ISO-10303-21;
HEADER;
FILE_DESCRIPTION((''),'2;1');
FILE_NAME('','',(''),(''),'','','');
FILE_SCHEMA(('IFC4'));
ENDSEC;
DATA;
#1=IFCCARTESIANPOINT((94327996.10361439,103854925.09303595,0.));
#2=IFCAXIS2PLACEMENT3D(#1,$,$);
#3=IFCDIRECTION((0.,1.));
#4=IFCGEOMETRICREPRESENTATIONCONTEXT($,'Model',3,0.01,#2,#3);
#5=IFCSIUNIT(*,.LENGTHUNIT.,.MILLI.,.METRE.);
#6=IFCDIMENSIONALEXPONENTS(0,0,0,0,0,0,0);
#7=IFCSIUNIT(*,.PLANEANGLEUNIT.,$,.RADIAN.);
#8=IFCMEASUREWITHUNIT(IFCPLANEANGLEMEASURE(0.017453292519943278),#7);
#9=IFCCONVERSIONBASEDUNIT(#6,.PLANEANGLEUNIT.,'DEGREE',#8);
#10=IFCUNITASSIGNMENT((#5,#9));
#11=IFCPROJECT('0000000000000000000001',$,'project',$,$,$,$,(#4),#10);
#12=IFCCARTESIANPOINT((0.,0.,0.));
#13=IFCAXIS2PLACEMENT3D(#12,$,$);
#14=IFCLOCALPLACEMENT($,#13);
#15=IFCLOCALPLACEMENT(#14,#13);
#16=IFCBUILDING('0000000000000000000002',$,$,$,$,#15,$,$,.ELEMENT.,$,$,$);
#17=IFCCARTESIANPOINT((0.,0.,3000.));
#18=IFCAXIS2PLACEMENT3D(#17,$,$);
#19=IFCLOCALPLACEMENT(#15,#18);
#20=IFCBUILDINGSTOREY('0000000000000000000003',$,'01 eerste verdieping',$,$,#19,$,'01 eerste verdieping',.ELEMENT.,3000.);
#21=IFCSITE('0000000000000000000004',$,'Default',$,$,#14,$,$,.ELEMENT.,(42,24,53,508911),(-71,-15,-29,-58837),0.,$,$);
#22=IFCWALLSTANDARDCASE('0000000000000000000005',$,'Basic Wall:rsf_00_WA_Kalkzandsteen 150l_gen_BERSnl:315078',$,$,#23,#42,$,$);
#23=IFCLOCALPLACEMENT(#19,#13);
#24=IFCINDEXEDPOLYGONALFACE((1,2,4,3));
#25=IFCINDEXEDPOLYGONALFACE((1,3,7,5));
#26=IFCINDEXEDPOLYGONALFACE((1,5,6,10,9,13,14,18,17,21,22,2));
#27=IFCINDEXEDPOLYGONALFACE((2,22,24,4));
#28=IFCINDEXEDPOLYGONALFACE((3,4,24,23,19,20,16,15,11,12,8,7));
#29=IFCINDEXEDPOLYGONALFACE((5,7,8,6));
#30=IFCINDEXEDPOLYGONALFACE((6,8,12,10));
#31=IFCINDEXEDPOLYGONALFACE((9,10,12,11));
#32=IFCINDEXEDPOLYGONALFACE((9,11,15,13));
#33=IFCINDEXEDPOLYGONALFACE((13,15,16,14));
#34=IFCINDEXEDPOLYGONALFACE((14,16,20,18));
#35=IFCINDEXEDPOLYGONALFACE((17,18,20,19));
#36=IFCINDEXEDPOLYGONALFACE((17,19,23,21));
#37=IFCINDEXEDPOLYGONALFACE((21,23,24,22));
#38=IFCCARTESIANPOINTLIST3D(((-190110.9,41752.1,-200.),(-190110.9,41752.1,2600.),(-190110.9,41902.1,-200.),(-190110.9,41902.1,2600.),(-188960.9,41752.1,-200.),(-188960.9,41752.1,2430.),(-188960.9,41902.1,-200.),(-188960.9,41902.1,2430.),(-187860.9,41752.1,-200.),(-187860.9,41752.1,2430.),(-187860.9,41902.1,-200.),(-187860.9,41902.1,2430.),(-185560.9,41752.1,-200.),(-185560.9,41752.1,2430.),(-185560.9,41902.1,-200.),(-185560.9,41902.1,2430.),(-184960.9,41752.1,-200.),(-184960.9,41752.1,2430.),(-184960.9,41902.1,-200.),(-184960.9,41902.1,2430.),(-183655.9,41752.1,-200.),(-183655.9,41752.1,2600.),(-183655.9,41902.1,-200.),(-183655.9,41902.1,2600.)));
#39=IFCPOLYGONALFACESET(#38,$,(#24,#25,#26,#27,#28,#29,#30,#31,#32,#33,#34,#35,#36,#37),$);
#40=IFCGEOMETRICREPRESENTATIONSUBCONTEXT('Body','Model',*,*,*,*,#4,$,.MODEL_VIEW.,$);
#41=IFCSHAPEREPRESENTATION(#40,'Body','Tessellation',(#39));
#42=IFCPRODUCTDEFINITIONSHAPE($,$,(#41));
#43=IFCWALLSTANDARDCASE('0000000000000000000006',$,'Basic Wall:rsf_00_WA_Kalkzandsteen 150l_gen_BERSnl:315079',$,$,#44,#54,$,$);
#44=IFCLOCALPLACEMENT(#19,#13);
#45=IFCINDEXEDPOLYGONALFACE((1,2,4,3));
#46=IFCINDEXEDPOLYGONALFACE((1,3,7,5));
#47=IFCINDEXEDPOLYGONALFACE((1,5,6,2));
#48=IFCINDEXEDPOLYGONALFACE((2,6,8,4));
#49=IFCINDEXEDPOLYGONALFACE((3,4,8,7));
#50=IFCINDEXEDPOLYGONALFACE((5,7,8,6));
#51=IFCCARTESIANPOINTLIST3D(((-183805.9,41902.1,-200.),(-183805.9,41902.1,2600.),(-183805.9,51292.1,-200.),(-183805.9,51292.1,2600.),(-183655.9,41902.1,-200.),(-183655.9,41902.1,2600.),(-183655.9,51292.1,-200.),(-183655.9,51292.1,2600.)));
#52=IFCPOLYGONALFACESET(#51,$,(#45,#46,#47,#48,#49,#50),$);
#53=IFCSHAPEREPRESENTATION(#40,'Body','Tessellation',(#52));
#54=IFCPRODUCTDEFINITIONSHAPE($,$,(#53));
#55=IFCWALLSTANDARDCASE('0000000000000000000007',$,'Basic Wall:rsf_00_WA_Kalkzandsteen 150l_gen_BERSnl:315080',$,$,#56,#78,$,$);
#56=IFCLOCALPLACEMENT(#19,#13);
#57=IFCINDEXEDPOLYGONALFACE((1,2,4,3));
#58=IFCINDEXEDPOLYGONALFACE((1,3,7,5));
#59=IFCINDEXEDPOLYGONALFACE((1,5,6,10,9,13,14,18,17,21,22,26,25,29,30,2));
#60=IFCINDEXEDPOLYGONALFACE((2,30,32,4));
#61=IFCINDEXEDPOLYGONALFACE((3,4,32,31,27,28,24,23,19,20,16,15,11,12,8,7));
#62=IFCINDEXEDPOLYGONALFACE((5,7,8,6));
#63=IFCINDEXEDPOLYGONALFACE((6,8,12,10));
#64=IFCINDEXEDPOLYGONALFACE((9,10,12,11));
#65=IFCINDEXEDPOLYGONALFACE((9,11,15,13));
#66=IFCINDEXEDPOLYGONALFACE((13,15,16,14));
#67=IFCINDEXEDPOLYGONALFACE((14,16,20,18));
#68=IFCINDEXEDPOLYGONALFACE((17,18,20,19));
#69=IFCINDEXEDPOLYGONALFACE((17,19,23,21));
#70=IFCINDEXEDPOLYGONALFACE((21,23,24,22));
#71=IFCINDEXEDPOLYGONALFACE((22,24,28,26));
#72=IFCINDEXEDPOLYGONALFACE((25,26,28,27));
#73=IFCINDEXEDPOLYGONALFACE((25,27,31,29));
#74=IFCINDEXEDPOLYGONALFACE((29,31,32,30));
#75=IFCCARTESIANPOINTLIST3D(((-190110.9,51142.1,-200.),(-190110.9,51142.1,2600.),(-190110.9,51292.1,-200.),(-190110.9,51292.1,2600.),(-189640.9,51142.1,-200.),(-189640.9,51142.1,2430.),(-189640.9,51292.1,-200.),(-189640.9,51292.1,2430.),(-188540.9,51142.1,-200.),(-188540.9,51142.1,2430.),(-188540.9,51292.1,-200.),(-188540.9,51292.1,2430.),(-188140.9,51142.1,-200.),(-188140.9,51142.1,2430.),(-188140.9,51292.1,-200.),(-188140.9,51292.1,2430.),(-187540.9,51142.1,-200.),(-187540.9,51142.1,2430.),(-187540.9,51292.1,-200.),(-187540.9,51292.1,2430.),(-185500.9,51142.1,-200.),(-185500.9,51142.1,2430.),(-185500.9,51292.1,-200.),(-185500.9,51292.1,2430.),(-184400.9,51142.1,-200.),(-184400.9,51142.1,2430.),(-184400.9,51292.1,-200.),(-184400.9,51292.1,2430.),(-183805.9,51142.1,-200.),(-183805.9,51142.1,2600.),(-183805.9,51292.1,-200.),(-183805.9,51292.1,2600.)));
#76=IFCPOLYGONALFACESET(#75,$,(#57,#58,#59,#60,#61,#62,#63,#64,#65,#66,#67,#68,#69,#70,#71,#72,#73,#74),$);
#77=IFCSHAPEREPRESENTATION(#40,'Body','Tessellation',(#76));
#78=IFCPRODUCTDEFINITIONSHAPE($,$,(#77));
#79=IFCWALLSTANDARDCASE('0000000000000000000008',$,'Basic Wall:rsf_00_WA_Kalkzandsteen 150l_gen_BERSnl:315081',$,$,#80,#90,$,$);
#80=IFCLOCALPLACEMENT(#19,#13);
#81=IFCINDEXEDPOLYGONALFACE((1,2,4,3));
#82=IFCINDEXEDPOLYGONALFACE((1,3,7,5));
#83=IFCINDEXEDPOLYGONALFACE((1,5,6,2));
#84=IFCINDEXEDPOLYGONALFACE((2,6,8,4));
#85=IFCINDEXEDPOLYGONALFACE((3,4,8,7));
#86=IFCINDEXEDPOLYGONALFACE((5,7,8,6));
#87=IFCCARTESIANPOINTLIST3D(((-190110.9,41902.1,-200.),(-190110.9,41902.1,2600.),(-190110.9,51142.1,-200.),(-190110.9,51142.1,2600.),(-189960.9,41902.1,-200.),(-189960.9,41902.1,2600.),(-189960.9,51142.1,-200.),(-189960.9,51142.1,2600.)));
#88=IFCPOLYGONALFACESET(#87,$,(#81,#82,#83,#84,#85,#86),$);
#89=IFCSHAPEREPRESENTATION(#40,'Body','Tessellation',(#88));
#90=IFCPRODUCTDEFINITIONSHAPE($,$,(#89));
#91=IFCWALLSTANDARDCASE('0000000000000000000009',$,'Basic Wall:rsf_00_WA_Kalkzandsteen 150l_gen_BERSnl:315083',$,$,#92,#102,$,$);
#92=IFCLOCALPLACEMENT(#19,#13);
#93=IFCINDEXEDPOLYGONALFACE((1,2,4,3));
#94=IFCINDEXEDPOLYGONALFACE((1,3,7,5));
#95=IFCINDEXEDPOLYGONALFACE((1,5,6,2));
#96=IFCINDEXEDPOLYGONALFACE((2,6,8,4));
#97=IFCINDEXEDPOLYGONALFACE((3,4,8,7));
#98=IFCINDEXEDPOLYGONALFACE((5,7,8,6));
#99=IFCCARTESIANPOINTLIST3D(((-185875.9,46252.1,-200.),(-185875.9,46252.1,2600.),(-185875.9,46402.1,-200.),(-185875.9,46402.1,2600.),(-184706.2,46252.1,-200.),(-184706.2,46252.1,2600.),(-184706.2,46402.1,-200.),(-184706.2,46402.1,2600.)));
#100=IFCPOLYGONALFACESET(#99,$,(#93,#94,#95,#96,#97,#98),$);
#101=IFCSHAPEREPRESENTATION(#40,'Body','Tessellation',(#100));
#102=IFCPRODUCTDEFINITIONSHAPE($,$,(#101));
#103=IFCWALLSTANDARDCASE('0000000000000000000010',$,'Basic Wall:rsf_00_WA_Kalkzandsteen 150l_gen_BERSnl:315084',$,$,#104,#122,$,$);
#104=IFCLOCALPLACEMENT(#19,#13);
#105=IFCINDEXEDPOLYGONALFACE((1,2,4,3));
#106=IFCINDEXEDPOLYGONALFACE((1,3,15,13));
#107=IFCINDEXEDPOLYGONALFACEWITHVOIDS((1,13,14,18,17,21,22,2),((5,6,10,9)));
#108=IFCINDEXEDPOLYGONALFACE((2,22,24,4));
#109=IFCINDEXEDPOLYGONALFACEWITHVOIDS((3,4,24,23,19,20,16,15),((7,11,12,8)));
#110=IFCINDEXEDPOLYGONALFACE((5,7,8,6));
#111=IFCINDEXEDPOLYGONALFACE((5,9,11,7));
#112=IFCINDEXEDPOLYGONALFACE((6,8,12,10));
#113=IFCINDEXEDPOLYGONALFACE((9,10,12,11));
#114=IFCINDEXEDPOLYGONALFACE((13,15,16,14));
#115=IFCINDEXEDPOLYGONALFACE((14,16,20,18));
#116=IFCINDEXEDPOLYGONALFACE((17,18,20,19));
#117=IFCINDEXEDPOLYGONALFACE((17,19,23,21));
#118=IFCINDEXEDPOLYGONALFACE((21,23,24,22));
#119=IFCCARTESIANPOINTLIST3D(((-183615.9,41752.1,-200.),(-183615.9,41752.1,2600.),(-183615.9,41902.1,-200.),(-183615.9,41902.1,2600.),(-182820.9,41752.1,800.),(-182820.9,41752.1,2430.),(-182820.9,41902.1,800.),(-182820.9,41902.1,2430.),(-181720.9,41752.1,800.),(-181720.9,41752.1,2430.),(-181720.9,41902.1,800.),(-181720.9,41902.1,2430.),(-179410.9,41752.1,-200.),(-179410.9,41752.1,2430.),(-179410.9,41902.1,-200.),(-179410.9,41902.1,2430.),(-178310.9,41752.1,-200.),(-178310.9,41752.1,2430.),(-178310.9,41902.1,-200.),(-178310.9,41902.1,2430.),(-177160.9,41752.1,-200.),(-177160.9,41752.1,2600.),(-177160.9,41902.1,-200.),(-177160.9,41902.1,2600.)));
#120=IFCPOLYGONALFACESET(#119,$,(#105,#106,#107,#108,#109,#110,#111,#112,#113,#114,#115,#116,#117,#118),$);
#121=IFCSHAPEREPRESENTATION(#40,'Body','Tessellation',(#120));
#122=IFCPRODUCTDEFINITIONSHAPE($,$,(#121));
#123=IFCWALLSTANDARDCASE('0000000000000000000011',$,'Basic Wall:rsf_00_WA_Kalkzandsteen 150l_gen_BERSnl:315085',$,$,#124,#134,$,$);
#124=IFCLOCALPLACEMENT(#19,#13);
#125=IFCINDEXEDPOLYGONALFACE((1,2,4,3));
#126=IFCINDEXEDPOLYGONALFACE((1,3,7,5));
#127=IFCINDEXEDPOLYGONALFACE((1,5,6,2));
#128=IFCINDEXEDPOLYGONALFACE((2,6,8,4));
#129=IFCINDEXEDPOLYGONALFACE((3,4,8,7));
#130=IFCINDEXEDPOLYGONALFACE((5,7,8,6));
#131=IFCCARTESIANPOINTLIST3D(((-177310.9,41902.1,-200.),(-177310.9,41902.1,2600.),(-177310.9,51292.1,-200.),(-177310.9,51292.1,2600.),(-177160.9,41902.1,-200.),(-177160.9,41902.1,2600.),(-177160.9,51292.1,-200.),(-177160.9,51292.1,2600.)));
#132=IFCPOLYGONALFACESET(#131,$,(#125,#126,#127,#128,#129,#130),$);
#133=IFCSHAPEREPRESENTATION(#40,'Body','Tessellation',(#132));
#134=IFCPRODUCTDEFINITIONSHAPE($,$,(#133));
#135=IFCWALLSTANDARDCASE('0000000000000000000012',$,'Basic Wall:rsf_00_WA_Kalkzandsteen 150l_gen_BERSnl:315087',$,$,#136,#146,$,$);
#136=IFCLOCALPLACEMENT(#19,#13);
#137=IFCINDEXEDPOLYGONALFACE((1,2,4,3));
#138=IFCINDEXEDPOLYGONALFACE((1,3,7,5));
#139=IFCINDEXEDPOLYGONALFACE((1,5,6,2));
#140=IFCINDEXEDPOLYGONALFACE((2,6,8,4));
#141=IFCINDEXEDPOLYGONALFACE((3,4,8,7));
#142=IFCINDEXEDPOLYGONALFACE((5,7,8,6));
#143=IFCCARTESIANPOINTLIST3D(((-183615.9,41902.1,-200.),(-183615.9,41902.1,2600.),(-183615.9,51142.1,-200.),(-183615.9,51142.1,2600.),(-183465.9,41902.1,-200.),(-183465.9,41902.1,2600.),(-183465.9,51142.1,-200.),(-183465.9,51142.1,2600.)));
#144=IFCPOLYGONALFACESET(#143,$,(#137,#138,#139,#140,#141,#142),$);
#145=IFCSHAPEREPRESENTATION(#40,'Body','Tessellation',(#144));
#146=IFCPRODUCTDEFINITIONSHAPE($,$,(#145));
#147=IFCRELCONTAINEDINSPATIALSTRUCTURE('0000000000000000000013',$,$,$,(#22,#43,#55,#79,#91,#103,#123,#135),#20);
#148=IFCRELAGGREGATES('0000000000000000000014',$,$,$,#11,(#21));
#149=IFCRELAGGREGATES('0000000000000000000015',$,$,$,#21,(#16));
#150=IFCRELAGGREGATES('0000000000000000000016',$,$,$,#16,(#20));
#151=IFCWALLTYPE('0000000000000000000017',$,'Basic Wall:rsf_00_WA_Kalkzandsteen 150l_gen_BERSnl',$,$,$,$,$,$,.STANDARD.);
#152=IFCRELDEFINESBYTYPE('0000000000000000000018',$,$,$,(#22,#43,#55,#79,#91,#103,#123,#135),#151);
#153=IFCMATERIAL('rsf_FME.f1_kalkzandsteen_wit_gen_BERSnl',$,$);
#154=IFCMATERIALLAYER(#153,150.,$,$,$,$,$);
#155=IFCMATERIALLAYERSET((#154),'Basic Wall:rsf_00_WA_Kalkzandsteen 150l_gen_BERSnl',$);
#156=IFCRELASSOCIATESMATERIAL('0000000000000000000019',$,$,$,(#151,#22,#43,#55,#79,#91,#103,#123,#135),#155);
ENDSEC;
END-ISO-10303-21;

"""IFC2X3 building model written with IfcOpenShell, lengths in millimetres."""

from ifc_helpers import new_model, entity, si_unit, converted_unit, direction, frame, frame_2d, origin, origin_2d_with_axis, place, context, subcontext, project, spatial, polyline, rectangle, extrude, clip, bounded_halfspace, material, layer, layer_set, layer_usage, type_object, element, save


model = new_model("IFC2X3")

# Units and contexts
model_context = context("Model", 3, precision=0.01, world=frame((94327996.10361439, 103854925.09303595, 0.0)), true_north=direction((0.0, 1.0)))
body_context = subcontext(model_context, "Body", "Model", "MODEL_VIEW")
ifc_project = project(units=[si_unit("LENGTHUNIT", "METRE", prefix="MILLI"), converted_unit("PLANEANGLEUNIT", "DEGREE", entity("IfcPlaneAngleMeasure", 0.017453292519943278), si_unit("PLANEANGLEUNIT", "RADIAN"), dimensions=[0, 0, 0, 0, 0, 0, 0])], contexts=[model_context])

# Site, building, storey
site_placement = place(None, origin())
site = spatial("IfcSite", under=ifc_project, at=site_placement, Name="Default", CompositionType="ELEMENT", RefLatitude=(42, 24, 53, 508911), RefLongitude=(-71, -15, -29, -58837), RefElevation=0.0)
building_placement = place(site_placement, origin())
building = spatial("IfcBuilding", under=site, at=building_placement, CompositionType="ELEMENT")
storey_placement = place(building_placement, frame((0.0, 0.0, 3000.0)))
storey = spatial("IfcBuildingStorey", under=building, at=storey_placement, Name="01 eerste verdieping", LongName="01 eerste verdieping", CompositionType="ELEMENT", Elevation=3000.0)

# Wall, openings
ifc_material = material(Name="rsf_FME.f1_kalkzandsteen_wit_gen_BERSnl")
ifc_layer = layer(ifc_material, 150.0)
ifc_layer_set = layer_set([ifc_layer], Name="Basic Wall:rsf_00_WA_Kalkzandsteen 150l_gen_BERSnl")
ifc_layer_usage_1 = layer_usage(ifc_layer_set, "AXIS2", "POSITIVE", -75.0)
wall_type = type_object("IfcWallType", Name="Basic Wall:rsf_00_WA_Kalkzandsteen 150l_gen_BERSnl", PredefinedType="STANDARD", material=ifc_layer_set)
wall_1_placement = place(storey_placement, frame((-190110.9, 41827.1, -200.0)))
wall_1 = element("IfcWallStandardCase", 1, at=wall_1_placement, inside=storey, type_object=wall_type, material=ifc_layer_usage_1, Name="Basic Wall:rsf_00_WA_Kalkzandsteen 150l_gen_BERSnl:315078", context=body_context, shape_type="Clipping", body=[
    clip(extrude(rectangle(XDim=6455.0, YDim=150.0, at=frame_2d((3227.5, 0.0), x_axis=(1.0, 0.0))), origin(), (0.0, 0.0, 1.0), 2800.0), bounded_halfspace(frame((0.0, -75.0, 2800.0), z_axis=(0.0, 0.0, -1.0), x_axis=(0.0, 1.0, 0.0)), True, frame((0.0, -75.0, 2800.0)), polyline([(0.0, 0.0), (6455.0, 0.0), (6455.0, 150.0), (6305.0, 150.0), (3363.5, 150.0), (3213.5, 150.0), (150.0, 150.0), (0.0, 150.0), (0.0, 0.0)]))),
])
opening_1_placement = place(wall_1_placement, frame((190110.9, -41827.1, 200.0)))
element("IfcOpeningElement", 2, at=opening_1_placement, cuts=wall_1, ObjectType="Opening", context=body_context, shape_type="SweptSolid", body=[
    extrude(rectangle(XDim=2630.0, YDim=600.0, at=origin_2d_with_axis()), frame((-185260.9, 40378.1, 1115.0), z_axis=(0.0, 1.0, 0.0), x_axis=(0.0, 0.0, 1.0)), (0.0, 0.0, 1.0), 3048.0),
])
opening_2_placement = place(wall_1_placement, frame((190110.9, -41827.1, 200.0)))
element("IfcOpeningElement", 3, at=opening_2_placement, cuts=wall_1, ObjectType="Opening", context=body_context, shape_type="SweptSolid", body=[
    extrude(rectangle(XDim=2630.0, YDim=1100.0, at=frame_2d((0.0, 0.0), x_axis=(1.0, 0.0))), frame((-188410.9, 40378.1, 1115.0), z_axis=(0.0, 1.0, 0.0), x_axis=(0.0, 0.0, 1.0)), (0.0, 0.0, 1.0), 3048.0),
])

# Wall
ifc_layer_usage_2 = layer_usage(ifc_layer_set, "AXIS2", "POSITIVE", -75.0)
wall_2_placement = place(storey_placement, frame((-183730.9, 41902.1, -200.0), z_axis=(0.0, 0.0, 1.0), x_axis=(0.0, 1.0, 0.0)))
element("IfcWallStandardCase", 4, at=wall_2_placement, inside=storey, type_object=wall_type, material=ifc_layer_usage_2, Name="Basic Wall:rsf_00_WA_Kalkzandsteen 150l_gen_BERSnl:315079", context=body_context, shape_type="Clipping", body=[
    clip(extrude(rectangle(XDim=9390.0, YDim=150.0, at=frame_2d((4695.0, 0.0), x_axis=(-1.0, 0.0))), origin(), (0.0, 0.0, 1.0), 2800.0), bounded_halfspace(frame((0.0, -75.0, 2800.0), z_axis=(0.0, 0.0, -1.0), x_axis=(1.0, 0.0, 0.0)), True, frame((0.0, -75.0, 2800.0)), polyline([(0.0, 0.0), (9390.0, 0.0), (9390.0, 150.0), (9240.0, 150.0), (0.0, 150.0), (0.0, 0.0)]))),
])

# Wall, openings
ifc_layer_usage_3 = layer_usage(ifc_layer_set, "AXIS2", "POSITIVE", -75.0)
wall_3_placement = place(storey_placement, frame((-183805.9, 51217.1, -200.0), z_axis=(0.0, 0.0, 1.0), x_axis=(-1.0, 0.0, 0.0)))
wall_3 = element("IfcWallStandardCase", 5, at=wall_3_placement, inside=storey, type_object=wall_type, material=ifc_layer_usage_3, Name="Basic Wall:rsf_00_WA_Kalkzandsteen 150l_gen_BERSnl:315080", context=body_context, shape_type="Clipping", body=[
    clip(extrude(rectangle(XDim=6305.0, YDim=150.0, at=frame_2d((3152.5, 0.0), x_axis=(-1.0, 0.0))), origin(), (0.0, 0.0, 1.0), 2800.0), bounded_halfspace(frame((0.0, -75.0, 2800.0), z_axis=(0.0, 0.0, -1.0), x_axis=(0.0, -1.0, 0.0)), True, frame((0.0, -75.0, 2800.0)), polyline([(0.0, 0.0), (6305.0, 0.0), (6305.0, 150.0), (6155.0, 150.0), (3091.5, 150.0), (2941.5, 150.0), (0.0, 150.0), (0.0, 0.0)]))),
])
opening_3_placement = place(wall_3_placement, frame((-183805.9, 51217.1, 200.0), z_axis=(0.0, 0.0, 1.0), x_axis=(-1.0, 0.0, 0.0)))
element("IfcOpeningElement", 6, at=opening_3_placement, cuts=wall_3, ObjectType="Opening", context=body_context, shape_type="SweptSolid", body=[
    extrude(rectangle(XDim=2630.0, YDim=1100.0, at=frame_2d((0.0, 0.0), x_axis=(0.0, 1.0))), frame((-184950.9, 52816.1, 1115.0), z_axis=(0.0, -1.0, 0.0), x_axis=(1.0, 0.0, 0.0)), (0.0, 0.0, 1.0), 3048.0),
])
opening_4_placement = place(wall_3_placement, frame((-183805.9, 51217.1, 200.0), z_axis=(0.0, 0.0, 1.0), x_axis=(-1.0, 0.0, 0.0)))
element("IfcOpeningElement", 7, at=opening_4_placement, cuts=wall_3, ObjectType="Opening", context=body_context, shape_type="SweptSolid", body=[
    extrude(rectangle(XDim=2630.0, YDim=1100.0, at=frame_2d((0.0, 0.0), x_axis=(0.0, 1.0))), frame((-189090.9, 52816.1, 1115.0), z_axis=(0.0, -1.0, 0.0), x_axis=(1.0, 0.0, 0.0)), (0.0, 0.0, 1.0), 3048.0),
])
opening_5_placement = place(wall_3_placement, frame((-183805.9, 51217.1, 200.0), z_axis=(0.0, 0.0, 1.0), x_axis=(-1.0, 0.0, 0.0)))
element("IfcOpeningElement", 8, at=opening_5_placement, cuts=wall_3, ObjectType="Opening", context=body_context, shape_type="SweptSolid", body=[
    extrude(rectangle(XDim=2630.0, YDim=600.0, at=frame_2d((0.0, 0.0), x_axis=(0.0, 1.0))), frame((-187840.9, 52816.1, 1115.0), z_axis=(0.0, -1.0, 0.0), x_axis=(1.0, 0.0, 0.0)), (0.0, 0.0, 1.0), 3048.0),
])

# Walls
ifc_layer_usage_4 = layer_usage(ifc_layer_set, "AXIS2", "POSITIVE", -75.0)
wall_4_placement = place(storey_placement, frame((-190035.9, 51142.1, -200.0), z_axis=(0.0, 0.0, 1.0), x_axis=(0.0, -1.0, 0.0)))
element("IfcWallStandardCase", 9, at=wall_4_placement, inside=storey, type_object=wall_type, material=ifc_layer_usage_4, Name="Basic Wall:rsf_00_WA_Kalkzandsteen 150l_gen_BERSnl:315081", context=body_context, shape_type="Clipping", body=[
    clip(extrude(rectangle(XDim=9240.0, YDim=150.0, at=frame_2d((4620.0, 0.0), x_axis=(-1.0, 0.0))), origin(), (0.0, 0.0, 1.0), 2800.0), bounded_halfspace(frame((0.0, -75.0, 2800.0), z_axis=(0.0, 0.0, -1.0), x_axis=(-1.0, 0.0, 0.0)), True, frame((0.0, -75.0, 2800.0)), polyline([(0.0, 0.0), (9240.0, 0.0), (9240.0, 150.0), (0.0, 150.0), (0.0, 0.0)]))),
])
ifc_layer_usage_5 = layer_usage(ifc_layer_set, "AXIS2", "NEGATIVE", 75.0)
wall_5_placement = place(storey_placement, frame((-185875.9, 46327.1, -200.0)))
element("IfcWallStandardCase", 10, at=wall_5_placement, inside=storey, type_object=wall_type, material=ifc_layer_usage_5, Name="Basic Wall:rsf_00_WA_Kalkzandsteen 150l_gen_BERSnl:315083", context=body_context, shape_type="Clipping", body=[
    clip(extrude(rectangle(XDim=1169.6, YDim=150.0, at=frame_2d((584.8, 0.0), x_axis=(-1.0, 0.0))), origin(), (0.0, 0.0, 1.0), 2800.0), bounded_halfspace(frame((0.0, -75.0, 2800.0), z_axis=(0.0, 0.0, -1.0), x_axis=(0.0, 1.0, 0.0)), True, frame((0.0, -75.0, 2800.0)), polyline([(0.0, 0.0), (1169.6, 0.0), (1169.6, 150.0), (0.0, 150.0), (0.0, 0.0)]))),
])

# Wall, openings
ifc_layer_usage_6 = layer_usage(ifc_layer_set, "AXIS2", "NEGATIVE", 75.0)
wall_6_placement = place(storey_placement, frame((-183615.9, 41827.1, -200.0)))
wall_6 = element("IfcWallStandardCase", 11, at=wall_6_placement, inside=storey, type_object=wall_type, material=ifc_layer_usage_6, Name="Basic Wall:rsf_00_WA_Kalkzandsteen 150l_gen_BERSnl:315084", context=body_context, shape_type="Clipping", body=[
    clip(extrude(rectangle(XDim=6455.0, YDim=150.0, at=frame_2d((3227.5, 0.0), x_axis=(-1.0, 0.0))), origin(), (0.0, 0.0, 1.0), 2800.0), bounded_halfspace(frame((0.0, -75.0, 2800.0), z_axis=(0.0, 0.0, -1.0), x_axis=(0.0, 1.0, 0.0)), True, frame((0.0, -75.0, 2800.0)), polyline([(0.0, 0.0), (6455.0, 0.0), (6455.0, 150.0), (6305.0, 150.0), (3241.5, 150.0), (3091.5, 150.0), (150.0, 150.0), (0.0, 150.0), (0.0, 0.0)]))),
])
opening_6_placement = place(wall_6_placement, frame((183615.9, -41827.1, 200.0)))
element("IfcOpeningElement", 12, at=opening_6_placement, cuts=wall_6, ObjectType="Opening", context=body_context, shape_type="SweptSolid", body=[
    extrude(rectangle(XDim=2630.0, YDim=1100.0, at=frame_2d((0.0, 0.0), x_axis=(0.0, 1.0))), frame((-178860.9, 40228.1, 1115.0), z_axis=(0.0, 1.0, 0.0), x_axis=(-1.0, 0.0, 0.0)), (0.0, 0.0, 1.0), 3048.0),
])
opening_7_placement = place(wall_6_placement, frame((183615.9, -41827.1, 200.0)))
element("IfcOpeningElement", 13, at=opening_7_placement, cuts=wall_6, ObjectType="Opening", context=body_context, shape_type="SweptSolid", body=[
    extrude(rectangle(XDim=1630.0, YDim=1100.0, at=frame_2d((0.0, 0.0), x_axis=(1.0, 0.0))), frame((-182270.9, 40378.1, 1615.0), z_axis=(0.0, 1.0, 0.0), x_axis=(0.0, 0.0, 1.0)), (0.0, 0.0, 1.0), 3048.0),
])

# Walls
ifc_layer_usage_7 = layer_usage(ifc_layer_set, "AXIS2", "NEGATIVE", 75.0)
wall_7_placement = place(storey_placement, frame((-177235.9, 41902.1, -200.0), z_axis=(0.0, 0.0, 1.0), x_axis=(0.0, 1.0, 0.0)))
element("IfcWallStandardCase", 14, at=wall_7_placement, inside=storey, type_object=wall_type, material=ifc_layer_usage_7, Name="Basic Wall:rsf_00_WA_Kalkzandsteen 150l_gen_BERSnl:315085", context=body_context, shape_type="Clipping", body=[
    clip(extrude(rectangle(XDim=9390.0, YDim=150.0, at=frame_2d((4695.0, 0.0), x_axis=(-1.0, 0.0))), origin(), (0.0, 0.0, 1.0), 2800.0), bounded_halfspace(frame((0.0, -75.0, 2800.0), z_axis=(0.0, 0.0, -1.0), x_axis=(1.0, 0.0, 0.0)), True, frame((0.0, -75.0, 2800.0)), polyline([(0.0, 0.0), (850.0, 0.0), (9390.0, 0.0), (9390.0, 150.0), (9240.0, 150.0), (0.0, 150.0), (0.0, 0.0)]))),
])
ifc_layer_usage_8 = layer_usage(ifc_layer_set, "AXIS2", "NEGATIVE", 75.0)
wall_8_placement = place(storey_placement, frame((-183540.9, 51142.1, -200.0), z_axis=(0.0, 0.0, 1.0), x_axis=(0.0, -1.0, 0.0)))
element("IfcWallStandardCase", 15, at=wall_8_placement, inside=storey, type_object=wall_type, material=ifc_layer_usage_8, Name="Basic Wall:rsf_00_WA_Kalkzandsteen 150l_gen_BERSnl:315087", context=body_context, shape_type="Clipping", body=[
    clip(extrude(rectangle(XDim=9240.0, YDim=150.0, at=frame_2d((4620.0, 0.0), x_axis=(-1.0, 0.0))), origin(), (0.0, 0.0, 1.0), 2800.0), bounded_halfspace(frame((0.0, -75.0, 2800.0), z_axis=(0.0, 0.0, -1.0), x_axis=(-1.0, 0.0, 0.0)), True, frame((0.0, -75.0, 2800.0)), polyline([(0.0, 0.0), (9240.0, 0.0), (9240.0, 150.0), (0.0, 150.0), (0.0, 0.0)]))),
])

save(model, "model.ifc")
